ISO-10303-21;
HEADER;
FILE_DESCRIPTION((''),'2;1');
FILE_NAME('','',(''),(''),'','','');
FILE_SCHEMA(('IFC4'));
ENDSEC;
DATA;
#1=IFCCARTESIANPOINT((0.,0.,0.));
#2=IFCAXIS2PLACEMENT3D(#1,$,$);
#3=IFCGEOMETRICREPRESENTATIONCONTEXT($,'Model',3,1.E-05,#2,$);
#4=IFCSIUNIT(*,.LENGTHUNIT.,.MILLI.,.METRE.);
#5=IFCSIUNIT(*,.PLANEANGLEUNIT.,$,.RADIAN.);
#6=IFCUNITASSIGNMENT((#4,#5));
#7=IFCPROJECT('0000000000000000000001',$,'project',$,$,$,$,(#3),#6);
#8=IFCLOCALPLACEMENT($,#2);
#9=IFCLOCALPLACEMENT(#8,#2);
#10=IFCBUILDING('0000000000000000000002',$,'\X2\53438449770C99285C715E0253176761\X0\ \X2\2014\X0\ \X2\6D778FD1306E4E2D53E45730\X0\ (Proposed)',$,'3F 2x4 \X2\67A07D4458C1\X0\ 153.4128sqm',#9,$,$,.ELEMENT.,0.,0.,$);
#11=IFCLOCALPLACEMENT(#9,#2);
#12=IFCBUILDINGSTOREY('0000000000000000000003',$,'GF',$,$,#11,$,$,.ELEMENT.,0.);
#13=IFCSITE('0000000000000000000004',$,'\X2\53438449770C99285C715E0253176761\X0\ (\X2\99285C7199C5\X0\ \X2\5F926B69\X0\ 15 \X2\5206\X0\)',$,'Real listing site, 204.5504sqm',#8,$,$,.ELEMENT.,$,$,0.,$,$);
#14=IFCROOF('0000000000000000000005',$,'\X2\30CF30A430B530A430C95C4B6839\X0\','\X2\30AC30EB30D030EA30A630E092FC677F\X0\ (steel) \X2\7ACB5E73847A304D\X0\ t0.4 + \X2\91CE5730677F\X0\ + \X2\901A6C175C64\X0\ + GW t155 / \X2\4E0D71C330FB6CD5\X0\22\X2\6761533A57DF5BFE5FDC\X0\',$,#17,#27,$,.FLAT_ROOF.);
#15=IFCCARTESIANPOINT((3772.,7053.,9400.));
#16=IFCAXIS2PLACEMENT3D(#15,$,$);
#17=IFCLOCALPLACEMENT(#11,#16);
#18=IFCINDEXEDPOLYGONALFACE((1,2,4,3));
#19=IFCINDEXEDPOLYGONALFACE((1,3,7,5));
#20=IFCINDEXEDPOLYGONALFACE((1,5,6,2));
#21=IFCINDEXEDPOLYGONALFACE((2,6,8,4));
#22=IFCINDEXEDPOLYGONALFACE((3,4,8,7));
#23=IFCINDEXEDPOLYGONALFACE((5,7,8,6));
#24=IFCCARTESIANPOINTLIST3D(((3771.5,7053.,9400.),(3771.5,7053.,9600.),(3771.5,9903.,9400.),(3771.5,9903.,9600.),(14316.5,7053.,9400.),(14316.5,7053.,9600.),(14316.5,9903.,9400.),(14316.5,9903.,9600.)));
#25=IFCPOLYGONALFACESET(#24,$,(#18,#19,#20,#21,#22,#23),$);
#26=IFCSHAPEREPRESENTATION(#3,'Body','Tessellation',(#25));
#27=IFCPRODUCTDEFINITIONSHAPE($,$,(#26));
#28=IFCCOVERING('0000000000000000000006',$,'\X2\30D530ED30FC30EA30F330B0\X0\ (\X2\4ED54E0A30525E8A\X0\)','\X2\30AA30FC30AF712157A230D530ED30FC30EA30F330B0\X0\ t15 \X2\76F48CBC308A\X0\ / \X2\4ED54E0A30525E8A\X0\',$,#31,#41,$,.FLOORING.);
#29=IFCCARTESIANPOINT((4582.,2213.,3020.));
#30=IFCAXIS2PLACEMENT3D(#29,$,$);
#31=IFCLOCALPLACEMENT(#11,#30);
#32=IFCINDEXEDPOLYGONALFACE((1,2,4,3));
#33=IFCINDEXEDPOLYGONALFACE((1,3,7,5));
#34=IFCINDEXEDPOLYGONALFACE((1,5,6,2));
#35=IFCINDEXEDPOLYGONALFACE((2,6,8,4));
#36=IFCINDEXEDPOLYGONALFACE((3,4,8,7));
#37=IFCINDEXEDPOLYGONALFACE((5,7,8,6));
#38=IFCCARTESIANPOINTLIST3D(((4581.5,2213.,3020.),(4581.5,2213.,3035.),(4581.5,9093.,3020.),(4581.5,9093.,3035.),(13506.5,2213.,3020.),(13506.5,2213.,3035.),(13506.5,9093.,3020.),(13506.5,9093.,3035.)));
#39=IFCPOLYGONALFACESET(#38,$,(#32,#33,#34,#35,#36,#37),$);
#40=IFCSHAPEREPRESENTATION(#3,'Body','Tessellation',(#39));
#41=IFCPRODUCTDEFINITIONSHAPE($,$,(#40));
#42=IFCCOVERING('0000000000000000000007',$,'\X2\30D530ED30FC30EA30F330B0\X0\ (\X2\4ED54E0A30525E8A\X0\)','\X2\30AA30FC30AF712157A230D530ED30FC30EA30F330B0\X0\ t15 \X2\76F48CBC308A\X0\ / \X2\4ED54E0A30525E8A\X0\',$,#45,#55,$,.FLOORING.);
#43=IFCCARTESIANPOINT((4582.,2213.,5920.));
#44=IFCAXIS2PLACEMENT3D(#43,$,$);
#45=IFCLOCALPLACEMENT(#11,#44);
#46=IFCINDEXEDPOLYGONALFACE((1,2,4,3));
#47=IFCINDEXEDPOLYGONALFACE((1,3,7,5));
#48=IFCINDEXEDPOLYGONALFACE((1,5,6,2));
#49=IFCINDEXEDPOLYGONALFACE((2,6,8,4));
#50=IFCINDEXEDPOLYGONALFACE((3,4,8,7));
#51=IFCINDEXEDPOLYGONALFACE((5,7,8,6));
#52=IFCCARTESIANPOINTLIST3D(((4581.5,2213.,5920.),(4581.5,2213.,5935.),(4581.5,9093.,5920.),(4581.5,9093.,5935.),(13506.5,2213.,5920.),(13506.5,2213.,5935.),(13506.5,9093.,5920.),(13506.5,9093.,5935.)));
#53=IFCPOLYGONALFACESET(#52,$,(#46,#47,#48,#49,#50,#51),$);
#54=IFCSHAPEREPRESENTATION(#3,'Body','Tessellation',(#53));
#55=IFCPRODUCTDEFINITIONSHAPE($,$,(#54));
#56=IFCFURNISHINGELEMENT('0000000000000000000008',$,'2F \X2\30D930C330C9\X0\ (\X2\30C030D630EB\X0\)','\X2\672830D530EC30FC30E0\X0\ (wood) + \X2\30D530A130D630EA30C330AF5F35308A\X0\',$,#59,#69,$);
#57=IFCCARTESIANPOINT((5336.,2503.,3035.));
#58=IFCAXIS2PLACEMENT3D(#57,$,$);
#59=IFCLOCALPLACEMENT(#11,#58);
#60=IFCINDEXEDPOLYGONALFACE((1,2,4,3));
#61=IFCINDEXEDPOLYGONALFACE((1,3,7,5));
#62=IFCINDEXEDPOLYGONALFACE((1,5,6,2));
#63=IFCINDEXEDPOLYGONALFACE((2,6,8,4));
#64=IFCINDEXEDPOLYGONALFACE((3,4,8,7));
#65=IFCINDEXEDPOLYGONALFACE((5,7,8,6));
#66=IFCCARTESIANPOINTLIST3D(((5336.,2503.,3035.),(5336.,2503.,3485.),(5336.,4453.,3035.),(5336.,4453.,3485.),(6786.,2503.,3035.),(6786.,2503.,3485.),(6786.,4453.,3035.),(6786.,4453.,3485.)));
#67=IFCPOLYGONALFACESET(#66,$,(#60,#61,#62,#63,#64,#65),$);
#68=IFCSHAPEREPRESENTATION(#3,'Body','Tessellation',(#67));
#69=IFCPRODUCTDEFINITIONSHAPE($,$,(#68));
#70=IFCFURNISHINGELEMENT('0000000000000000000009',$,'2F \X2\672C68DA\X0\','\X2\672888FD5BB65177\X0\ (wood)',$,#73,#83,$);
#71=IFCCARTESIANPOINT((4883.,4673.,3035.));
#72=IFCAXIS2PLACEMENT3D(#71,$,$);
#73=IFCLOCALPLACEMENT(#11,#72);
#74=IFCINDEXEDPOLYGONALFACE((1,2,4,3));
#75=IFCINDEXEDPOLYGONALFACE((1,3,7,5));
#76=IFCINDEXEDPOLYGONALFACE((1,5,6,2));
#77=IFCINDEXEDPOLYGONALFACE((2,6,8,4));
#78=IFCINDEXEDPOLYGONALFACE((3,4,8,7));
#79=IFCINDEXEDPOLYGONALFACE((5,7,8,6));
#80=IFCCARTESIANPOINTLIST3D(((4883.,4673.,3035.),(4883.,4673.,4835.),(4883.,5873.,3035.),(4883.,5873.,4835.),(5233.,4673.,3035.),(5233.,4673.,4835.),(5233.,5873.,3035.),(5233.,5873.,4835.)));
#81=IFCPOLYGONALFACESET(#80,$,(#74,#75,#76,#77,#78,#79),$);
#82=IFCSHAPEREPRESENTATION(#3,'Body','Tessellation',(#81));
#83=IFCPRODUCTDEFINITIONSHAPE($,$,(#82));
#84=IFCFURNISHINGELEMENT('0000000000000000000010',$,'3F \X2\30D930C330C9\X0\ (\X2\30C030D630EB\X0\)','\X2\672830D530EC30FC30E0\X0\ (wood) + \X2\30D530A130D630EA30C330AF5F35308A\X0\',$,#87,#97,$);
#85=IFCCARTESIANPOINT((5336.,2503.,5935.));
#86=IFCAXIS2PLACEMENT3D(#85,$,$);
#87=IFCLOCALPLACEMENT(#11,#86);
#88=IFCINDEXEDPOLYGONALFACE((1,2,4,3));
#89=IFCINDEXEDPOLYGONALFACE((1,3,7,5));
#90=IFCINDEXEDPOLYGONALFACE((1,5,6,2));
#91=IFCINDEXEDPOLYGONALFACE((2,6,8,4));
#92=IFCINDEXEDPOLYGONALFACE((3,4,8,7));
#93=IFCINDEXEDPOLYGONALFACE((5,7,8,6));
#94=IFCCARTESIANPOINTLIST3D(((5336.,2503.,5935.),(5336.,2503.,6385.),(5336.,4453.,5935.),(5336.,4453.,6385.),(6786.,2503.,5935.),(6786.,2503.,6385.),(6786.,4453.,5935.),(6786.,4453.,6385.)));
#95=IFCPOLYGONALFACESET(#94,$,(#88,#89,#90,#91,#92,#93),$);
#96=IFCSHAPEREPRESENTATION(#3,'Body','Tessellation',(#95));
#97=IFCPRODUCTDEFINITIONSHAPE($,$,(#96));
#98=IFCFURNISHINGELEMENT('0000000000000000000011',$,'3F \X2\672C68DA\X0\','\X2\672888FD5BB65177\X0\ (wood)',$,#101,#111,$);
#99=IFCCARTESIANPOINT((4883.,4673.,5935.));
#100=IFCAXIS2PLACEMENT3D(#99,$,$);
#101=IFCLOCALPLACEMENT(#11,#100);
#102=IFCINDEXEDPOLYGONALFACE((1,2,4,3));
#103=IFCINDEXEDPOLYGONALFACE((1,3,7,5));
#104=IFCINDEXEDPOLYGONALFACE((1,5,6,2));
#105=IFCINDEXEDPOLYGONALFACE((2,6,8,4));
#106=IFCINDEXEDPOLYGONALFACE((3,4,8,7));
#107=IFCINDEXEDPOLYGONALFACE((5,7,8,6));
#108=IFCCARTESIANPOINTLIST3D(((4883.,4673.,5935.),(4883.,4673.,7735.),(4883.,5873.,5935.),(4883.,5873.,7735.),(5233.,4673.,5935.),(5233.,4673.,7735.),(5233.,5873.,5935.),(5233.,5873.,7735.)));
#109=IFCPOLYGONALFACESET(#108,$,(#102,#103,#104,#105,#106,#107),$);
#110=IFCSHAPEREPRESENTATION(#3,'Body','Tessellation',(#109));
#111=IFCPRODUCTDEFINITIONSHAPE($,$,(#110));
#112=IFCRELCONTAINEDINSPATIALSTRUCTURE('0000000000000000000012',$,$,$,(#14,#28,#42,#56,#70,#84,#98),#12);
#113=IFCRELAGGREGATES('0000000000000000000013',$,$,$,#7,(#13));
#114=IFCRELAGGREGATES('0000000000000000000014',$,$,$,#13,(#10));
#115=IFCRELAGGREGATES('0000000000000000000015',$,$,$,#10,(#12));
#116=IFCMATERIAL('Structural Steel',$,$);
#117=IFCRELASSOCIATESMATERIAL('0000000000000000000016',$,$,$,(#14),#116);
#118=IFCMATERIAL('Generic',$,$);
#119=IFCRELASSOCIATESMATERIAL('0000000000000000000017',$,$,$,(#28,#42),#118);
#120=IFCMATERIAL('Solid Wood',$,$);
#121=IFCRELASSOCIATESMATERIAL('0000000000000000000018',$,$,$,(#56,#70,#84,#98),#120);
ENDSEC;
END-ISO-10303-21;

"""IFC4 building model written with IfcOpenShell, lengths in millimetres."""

from ifc_helpers import new_model, si_unit, frame, frame_2d, origin, place, context, project, spatial, rectangle, extrude, material, element, save


model = new_model("IFC4")

# Units and contexts
model_context = context("Model", 3, precision=1e-05, world=origin())
ifc_project = project(units=[si_unit("LENGTHUNIT", "METRE", prefix="MILLI"), si_unit("PLANEANGLEUNIT", "RADIAN")], contexts=[model_context])

# Site, building, storey
site_placement = place(None, origin())
site = spatial("IfcSite", under=ifc_project, at=site_placement, Name="千葉県館山市北条 (館山駅 徒歩 15 分)", ObjectType="Real listing site, 204.5504sqm", CompositionType="ELEMENT", RefElevation=0.0)
building_placement = place(site_placement, origin())
building = spatial("IfcBuilding", under=site, at=building_placement, Name="千葉県館山市北条 — 海近の中古地 (Proposed)", ObjectType="3F 2x4 枠組壁 153.4128sqm", CompositionType="ELEMENT", ElevationOfRefHeight=0.0, ElevationOfTerrain=0.0)
storey_placement = place(building_placement, origin())
storey = spatial("IfcBuildingStorey", under=building, at=storey_placement, Name="GF", CompositionType="ELEMENT", Elevation=0.0)

# Shared definitions
ifc_material_1 = material(Name="Solid Wood")

# Roof
ifc_material_2 = material(Name="Structural Steel")
roof_1_placement = place(storey_placement, frame((3772.0, 7053.0, 9400.0)))
element("IfcRoof", 1, at=roof_1_placement, inside=storey, material=ifc_material_2, Name="ハイサイド屋根", Description="ガルバリウム鋼板 (steel) 立平葺き t0.4 + 野地板 + 通気層 + GW t155 / 不燃・法22条区域対応", PredefinedType="FLAT_ROOF", context=model_context, shape_type="SweptSolid", body=[
    extrude(rectangle(XDim=10545.0, YDim=2850.0, at=frame_2d((5272.0, 1425.0))), frame((3772.0, 7053.0, 9400.0)), (0.0, 0.0, 1.0), 200.0),
])

# Coverings
ifc_material_3 = material(Name="Generic")
covering_1_placement = place(storey_placement, frame((4582.0, 2213.0, 3020.0)))
element("IfcCovering", 2, at=covering_1_placement, inside=storey, material=ifc_material_3, Name="フローリング (仕上げ床)", Description="オーク無垢フローリング t15 直貼り / 仕上げ床", PredefinedType="FLOORING", context=model_context, shape_type="SweptSolid", body=[
    extrude(rectangle(XDim=8925.0, YDim=6880.0, at=frame_2d((4462.0, 3440.0))), frame((4582.0, 2213.0, 3020.0)), (0.0, 0.0, 1.0), 15.0),
])
covering_2_placement = place(storey_placement, frame((4582.0, 2213.0, 5920.0)))
element("IfcCovering", 3, at=covering_2_placement, inside=storey, material=ifc_material_3, Name="フローリング (仕上げ床)", Description="オーク無垢フローリング t15 直貼り / 仕上げ床", PredefinedType="FLOORING", context=model_context, shape_type="SweptSolid", body=[
    extrude(rectangle(XDim=8925.0, YDim=6880.0, at=frame_2d((4462.0, 3440.0))), frame((4582.0, 2213.0, 5920.0)), (0.0, 0.0, 1.0), 15.0),
])

# Furnishing elements
furnishing_1_placement = place(storey_placement, frame((5336.0, 2503.0, 3035.0)))
element("IfcFurnishingElement", 4, at=furnishing_1_placement, inside=storey, material=ifc_material_1, Name="2F ベッド (ダブル)", Description="木フレーム (wood) + ファブリック張り", context=model_context, shape_type="SweptSolid", body=[
    extrude(rectangle(XDim=1450.0, YDim=1950.0, at=frame_2d((725.0, 975.0))), frame((5336.0, 2503.0, 3035.0)), (0.0, 0.0, 1.0), 450.0),
])
furnishing_2_placement = place(storey_placement, frame((4883.0, 4673.0, 3035.0)))
element("IfcFurnishingElement", 5, at=furnishing_2_placement, inside=storey, material=ifc_material_1, Name="2F 本棚", Description="木製家具 (wood)", context=model_context, shape_type="SweptSolid", body=[
    extrude(rectangle(XDim=350.0, YDim=1200.0, at=frame_2d((175.0, 600.0))), frame((4883.0, 4673.0, 3035.0)), (0.0, 0.0, 1.0), 1800.0),
])
furnishing_3_placement = place(storey_placement, frame((5336.0, 2503.0, 5935.0)))
element("IfcFurnishingElement", 6, at=furnishing_3_placement, inside=storey, material=ifc_material_1, Name="3F ベッド (ダブル)", Description="木フレーム (wood) + ファブリック張り", context=model_context, shape_type="SweptSolid", body=[
    extrude(rectangle(XDim=1450.0, YDim=1950.0, at=frame_2d((725.0, 975.0))), frame((5336.0, 2503.0, 5935.0)), (0.0, 0.0, 1.0), 450.0),
])
furnishing_4_placement = place(storey_placement, frame((4883.0, 4673.0, 5935.0)))
element("IfcFurnishingElement", 7, at=furnishing_4_placement, inside=storey, material=ifc_material_1, Name="3F 本棚", Description="木製家具 (wood)", context=model_context, shape_type="SweptSolid", body=[
    extrude(rectangle(XDim=350.0, YDim=1200.0, at=frame_2d((175.0, 600.0))), frame((4883.0, 4673.0, 5935.0)), (0.0, 0.0, 1.0), 1800.0),
])

save(model, "model.ifc")
